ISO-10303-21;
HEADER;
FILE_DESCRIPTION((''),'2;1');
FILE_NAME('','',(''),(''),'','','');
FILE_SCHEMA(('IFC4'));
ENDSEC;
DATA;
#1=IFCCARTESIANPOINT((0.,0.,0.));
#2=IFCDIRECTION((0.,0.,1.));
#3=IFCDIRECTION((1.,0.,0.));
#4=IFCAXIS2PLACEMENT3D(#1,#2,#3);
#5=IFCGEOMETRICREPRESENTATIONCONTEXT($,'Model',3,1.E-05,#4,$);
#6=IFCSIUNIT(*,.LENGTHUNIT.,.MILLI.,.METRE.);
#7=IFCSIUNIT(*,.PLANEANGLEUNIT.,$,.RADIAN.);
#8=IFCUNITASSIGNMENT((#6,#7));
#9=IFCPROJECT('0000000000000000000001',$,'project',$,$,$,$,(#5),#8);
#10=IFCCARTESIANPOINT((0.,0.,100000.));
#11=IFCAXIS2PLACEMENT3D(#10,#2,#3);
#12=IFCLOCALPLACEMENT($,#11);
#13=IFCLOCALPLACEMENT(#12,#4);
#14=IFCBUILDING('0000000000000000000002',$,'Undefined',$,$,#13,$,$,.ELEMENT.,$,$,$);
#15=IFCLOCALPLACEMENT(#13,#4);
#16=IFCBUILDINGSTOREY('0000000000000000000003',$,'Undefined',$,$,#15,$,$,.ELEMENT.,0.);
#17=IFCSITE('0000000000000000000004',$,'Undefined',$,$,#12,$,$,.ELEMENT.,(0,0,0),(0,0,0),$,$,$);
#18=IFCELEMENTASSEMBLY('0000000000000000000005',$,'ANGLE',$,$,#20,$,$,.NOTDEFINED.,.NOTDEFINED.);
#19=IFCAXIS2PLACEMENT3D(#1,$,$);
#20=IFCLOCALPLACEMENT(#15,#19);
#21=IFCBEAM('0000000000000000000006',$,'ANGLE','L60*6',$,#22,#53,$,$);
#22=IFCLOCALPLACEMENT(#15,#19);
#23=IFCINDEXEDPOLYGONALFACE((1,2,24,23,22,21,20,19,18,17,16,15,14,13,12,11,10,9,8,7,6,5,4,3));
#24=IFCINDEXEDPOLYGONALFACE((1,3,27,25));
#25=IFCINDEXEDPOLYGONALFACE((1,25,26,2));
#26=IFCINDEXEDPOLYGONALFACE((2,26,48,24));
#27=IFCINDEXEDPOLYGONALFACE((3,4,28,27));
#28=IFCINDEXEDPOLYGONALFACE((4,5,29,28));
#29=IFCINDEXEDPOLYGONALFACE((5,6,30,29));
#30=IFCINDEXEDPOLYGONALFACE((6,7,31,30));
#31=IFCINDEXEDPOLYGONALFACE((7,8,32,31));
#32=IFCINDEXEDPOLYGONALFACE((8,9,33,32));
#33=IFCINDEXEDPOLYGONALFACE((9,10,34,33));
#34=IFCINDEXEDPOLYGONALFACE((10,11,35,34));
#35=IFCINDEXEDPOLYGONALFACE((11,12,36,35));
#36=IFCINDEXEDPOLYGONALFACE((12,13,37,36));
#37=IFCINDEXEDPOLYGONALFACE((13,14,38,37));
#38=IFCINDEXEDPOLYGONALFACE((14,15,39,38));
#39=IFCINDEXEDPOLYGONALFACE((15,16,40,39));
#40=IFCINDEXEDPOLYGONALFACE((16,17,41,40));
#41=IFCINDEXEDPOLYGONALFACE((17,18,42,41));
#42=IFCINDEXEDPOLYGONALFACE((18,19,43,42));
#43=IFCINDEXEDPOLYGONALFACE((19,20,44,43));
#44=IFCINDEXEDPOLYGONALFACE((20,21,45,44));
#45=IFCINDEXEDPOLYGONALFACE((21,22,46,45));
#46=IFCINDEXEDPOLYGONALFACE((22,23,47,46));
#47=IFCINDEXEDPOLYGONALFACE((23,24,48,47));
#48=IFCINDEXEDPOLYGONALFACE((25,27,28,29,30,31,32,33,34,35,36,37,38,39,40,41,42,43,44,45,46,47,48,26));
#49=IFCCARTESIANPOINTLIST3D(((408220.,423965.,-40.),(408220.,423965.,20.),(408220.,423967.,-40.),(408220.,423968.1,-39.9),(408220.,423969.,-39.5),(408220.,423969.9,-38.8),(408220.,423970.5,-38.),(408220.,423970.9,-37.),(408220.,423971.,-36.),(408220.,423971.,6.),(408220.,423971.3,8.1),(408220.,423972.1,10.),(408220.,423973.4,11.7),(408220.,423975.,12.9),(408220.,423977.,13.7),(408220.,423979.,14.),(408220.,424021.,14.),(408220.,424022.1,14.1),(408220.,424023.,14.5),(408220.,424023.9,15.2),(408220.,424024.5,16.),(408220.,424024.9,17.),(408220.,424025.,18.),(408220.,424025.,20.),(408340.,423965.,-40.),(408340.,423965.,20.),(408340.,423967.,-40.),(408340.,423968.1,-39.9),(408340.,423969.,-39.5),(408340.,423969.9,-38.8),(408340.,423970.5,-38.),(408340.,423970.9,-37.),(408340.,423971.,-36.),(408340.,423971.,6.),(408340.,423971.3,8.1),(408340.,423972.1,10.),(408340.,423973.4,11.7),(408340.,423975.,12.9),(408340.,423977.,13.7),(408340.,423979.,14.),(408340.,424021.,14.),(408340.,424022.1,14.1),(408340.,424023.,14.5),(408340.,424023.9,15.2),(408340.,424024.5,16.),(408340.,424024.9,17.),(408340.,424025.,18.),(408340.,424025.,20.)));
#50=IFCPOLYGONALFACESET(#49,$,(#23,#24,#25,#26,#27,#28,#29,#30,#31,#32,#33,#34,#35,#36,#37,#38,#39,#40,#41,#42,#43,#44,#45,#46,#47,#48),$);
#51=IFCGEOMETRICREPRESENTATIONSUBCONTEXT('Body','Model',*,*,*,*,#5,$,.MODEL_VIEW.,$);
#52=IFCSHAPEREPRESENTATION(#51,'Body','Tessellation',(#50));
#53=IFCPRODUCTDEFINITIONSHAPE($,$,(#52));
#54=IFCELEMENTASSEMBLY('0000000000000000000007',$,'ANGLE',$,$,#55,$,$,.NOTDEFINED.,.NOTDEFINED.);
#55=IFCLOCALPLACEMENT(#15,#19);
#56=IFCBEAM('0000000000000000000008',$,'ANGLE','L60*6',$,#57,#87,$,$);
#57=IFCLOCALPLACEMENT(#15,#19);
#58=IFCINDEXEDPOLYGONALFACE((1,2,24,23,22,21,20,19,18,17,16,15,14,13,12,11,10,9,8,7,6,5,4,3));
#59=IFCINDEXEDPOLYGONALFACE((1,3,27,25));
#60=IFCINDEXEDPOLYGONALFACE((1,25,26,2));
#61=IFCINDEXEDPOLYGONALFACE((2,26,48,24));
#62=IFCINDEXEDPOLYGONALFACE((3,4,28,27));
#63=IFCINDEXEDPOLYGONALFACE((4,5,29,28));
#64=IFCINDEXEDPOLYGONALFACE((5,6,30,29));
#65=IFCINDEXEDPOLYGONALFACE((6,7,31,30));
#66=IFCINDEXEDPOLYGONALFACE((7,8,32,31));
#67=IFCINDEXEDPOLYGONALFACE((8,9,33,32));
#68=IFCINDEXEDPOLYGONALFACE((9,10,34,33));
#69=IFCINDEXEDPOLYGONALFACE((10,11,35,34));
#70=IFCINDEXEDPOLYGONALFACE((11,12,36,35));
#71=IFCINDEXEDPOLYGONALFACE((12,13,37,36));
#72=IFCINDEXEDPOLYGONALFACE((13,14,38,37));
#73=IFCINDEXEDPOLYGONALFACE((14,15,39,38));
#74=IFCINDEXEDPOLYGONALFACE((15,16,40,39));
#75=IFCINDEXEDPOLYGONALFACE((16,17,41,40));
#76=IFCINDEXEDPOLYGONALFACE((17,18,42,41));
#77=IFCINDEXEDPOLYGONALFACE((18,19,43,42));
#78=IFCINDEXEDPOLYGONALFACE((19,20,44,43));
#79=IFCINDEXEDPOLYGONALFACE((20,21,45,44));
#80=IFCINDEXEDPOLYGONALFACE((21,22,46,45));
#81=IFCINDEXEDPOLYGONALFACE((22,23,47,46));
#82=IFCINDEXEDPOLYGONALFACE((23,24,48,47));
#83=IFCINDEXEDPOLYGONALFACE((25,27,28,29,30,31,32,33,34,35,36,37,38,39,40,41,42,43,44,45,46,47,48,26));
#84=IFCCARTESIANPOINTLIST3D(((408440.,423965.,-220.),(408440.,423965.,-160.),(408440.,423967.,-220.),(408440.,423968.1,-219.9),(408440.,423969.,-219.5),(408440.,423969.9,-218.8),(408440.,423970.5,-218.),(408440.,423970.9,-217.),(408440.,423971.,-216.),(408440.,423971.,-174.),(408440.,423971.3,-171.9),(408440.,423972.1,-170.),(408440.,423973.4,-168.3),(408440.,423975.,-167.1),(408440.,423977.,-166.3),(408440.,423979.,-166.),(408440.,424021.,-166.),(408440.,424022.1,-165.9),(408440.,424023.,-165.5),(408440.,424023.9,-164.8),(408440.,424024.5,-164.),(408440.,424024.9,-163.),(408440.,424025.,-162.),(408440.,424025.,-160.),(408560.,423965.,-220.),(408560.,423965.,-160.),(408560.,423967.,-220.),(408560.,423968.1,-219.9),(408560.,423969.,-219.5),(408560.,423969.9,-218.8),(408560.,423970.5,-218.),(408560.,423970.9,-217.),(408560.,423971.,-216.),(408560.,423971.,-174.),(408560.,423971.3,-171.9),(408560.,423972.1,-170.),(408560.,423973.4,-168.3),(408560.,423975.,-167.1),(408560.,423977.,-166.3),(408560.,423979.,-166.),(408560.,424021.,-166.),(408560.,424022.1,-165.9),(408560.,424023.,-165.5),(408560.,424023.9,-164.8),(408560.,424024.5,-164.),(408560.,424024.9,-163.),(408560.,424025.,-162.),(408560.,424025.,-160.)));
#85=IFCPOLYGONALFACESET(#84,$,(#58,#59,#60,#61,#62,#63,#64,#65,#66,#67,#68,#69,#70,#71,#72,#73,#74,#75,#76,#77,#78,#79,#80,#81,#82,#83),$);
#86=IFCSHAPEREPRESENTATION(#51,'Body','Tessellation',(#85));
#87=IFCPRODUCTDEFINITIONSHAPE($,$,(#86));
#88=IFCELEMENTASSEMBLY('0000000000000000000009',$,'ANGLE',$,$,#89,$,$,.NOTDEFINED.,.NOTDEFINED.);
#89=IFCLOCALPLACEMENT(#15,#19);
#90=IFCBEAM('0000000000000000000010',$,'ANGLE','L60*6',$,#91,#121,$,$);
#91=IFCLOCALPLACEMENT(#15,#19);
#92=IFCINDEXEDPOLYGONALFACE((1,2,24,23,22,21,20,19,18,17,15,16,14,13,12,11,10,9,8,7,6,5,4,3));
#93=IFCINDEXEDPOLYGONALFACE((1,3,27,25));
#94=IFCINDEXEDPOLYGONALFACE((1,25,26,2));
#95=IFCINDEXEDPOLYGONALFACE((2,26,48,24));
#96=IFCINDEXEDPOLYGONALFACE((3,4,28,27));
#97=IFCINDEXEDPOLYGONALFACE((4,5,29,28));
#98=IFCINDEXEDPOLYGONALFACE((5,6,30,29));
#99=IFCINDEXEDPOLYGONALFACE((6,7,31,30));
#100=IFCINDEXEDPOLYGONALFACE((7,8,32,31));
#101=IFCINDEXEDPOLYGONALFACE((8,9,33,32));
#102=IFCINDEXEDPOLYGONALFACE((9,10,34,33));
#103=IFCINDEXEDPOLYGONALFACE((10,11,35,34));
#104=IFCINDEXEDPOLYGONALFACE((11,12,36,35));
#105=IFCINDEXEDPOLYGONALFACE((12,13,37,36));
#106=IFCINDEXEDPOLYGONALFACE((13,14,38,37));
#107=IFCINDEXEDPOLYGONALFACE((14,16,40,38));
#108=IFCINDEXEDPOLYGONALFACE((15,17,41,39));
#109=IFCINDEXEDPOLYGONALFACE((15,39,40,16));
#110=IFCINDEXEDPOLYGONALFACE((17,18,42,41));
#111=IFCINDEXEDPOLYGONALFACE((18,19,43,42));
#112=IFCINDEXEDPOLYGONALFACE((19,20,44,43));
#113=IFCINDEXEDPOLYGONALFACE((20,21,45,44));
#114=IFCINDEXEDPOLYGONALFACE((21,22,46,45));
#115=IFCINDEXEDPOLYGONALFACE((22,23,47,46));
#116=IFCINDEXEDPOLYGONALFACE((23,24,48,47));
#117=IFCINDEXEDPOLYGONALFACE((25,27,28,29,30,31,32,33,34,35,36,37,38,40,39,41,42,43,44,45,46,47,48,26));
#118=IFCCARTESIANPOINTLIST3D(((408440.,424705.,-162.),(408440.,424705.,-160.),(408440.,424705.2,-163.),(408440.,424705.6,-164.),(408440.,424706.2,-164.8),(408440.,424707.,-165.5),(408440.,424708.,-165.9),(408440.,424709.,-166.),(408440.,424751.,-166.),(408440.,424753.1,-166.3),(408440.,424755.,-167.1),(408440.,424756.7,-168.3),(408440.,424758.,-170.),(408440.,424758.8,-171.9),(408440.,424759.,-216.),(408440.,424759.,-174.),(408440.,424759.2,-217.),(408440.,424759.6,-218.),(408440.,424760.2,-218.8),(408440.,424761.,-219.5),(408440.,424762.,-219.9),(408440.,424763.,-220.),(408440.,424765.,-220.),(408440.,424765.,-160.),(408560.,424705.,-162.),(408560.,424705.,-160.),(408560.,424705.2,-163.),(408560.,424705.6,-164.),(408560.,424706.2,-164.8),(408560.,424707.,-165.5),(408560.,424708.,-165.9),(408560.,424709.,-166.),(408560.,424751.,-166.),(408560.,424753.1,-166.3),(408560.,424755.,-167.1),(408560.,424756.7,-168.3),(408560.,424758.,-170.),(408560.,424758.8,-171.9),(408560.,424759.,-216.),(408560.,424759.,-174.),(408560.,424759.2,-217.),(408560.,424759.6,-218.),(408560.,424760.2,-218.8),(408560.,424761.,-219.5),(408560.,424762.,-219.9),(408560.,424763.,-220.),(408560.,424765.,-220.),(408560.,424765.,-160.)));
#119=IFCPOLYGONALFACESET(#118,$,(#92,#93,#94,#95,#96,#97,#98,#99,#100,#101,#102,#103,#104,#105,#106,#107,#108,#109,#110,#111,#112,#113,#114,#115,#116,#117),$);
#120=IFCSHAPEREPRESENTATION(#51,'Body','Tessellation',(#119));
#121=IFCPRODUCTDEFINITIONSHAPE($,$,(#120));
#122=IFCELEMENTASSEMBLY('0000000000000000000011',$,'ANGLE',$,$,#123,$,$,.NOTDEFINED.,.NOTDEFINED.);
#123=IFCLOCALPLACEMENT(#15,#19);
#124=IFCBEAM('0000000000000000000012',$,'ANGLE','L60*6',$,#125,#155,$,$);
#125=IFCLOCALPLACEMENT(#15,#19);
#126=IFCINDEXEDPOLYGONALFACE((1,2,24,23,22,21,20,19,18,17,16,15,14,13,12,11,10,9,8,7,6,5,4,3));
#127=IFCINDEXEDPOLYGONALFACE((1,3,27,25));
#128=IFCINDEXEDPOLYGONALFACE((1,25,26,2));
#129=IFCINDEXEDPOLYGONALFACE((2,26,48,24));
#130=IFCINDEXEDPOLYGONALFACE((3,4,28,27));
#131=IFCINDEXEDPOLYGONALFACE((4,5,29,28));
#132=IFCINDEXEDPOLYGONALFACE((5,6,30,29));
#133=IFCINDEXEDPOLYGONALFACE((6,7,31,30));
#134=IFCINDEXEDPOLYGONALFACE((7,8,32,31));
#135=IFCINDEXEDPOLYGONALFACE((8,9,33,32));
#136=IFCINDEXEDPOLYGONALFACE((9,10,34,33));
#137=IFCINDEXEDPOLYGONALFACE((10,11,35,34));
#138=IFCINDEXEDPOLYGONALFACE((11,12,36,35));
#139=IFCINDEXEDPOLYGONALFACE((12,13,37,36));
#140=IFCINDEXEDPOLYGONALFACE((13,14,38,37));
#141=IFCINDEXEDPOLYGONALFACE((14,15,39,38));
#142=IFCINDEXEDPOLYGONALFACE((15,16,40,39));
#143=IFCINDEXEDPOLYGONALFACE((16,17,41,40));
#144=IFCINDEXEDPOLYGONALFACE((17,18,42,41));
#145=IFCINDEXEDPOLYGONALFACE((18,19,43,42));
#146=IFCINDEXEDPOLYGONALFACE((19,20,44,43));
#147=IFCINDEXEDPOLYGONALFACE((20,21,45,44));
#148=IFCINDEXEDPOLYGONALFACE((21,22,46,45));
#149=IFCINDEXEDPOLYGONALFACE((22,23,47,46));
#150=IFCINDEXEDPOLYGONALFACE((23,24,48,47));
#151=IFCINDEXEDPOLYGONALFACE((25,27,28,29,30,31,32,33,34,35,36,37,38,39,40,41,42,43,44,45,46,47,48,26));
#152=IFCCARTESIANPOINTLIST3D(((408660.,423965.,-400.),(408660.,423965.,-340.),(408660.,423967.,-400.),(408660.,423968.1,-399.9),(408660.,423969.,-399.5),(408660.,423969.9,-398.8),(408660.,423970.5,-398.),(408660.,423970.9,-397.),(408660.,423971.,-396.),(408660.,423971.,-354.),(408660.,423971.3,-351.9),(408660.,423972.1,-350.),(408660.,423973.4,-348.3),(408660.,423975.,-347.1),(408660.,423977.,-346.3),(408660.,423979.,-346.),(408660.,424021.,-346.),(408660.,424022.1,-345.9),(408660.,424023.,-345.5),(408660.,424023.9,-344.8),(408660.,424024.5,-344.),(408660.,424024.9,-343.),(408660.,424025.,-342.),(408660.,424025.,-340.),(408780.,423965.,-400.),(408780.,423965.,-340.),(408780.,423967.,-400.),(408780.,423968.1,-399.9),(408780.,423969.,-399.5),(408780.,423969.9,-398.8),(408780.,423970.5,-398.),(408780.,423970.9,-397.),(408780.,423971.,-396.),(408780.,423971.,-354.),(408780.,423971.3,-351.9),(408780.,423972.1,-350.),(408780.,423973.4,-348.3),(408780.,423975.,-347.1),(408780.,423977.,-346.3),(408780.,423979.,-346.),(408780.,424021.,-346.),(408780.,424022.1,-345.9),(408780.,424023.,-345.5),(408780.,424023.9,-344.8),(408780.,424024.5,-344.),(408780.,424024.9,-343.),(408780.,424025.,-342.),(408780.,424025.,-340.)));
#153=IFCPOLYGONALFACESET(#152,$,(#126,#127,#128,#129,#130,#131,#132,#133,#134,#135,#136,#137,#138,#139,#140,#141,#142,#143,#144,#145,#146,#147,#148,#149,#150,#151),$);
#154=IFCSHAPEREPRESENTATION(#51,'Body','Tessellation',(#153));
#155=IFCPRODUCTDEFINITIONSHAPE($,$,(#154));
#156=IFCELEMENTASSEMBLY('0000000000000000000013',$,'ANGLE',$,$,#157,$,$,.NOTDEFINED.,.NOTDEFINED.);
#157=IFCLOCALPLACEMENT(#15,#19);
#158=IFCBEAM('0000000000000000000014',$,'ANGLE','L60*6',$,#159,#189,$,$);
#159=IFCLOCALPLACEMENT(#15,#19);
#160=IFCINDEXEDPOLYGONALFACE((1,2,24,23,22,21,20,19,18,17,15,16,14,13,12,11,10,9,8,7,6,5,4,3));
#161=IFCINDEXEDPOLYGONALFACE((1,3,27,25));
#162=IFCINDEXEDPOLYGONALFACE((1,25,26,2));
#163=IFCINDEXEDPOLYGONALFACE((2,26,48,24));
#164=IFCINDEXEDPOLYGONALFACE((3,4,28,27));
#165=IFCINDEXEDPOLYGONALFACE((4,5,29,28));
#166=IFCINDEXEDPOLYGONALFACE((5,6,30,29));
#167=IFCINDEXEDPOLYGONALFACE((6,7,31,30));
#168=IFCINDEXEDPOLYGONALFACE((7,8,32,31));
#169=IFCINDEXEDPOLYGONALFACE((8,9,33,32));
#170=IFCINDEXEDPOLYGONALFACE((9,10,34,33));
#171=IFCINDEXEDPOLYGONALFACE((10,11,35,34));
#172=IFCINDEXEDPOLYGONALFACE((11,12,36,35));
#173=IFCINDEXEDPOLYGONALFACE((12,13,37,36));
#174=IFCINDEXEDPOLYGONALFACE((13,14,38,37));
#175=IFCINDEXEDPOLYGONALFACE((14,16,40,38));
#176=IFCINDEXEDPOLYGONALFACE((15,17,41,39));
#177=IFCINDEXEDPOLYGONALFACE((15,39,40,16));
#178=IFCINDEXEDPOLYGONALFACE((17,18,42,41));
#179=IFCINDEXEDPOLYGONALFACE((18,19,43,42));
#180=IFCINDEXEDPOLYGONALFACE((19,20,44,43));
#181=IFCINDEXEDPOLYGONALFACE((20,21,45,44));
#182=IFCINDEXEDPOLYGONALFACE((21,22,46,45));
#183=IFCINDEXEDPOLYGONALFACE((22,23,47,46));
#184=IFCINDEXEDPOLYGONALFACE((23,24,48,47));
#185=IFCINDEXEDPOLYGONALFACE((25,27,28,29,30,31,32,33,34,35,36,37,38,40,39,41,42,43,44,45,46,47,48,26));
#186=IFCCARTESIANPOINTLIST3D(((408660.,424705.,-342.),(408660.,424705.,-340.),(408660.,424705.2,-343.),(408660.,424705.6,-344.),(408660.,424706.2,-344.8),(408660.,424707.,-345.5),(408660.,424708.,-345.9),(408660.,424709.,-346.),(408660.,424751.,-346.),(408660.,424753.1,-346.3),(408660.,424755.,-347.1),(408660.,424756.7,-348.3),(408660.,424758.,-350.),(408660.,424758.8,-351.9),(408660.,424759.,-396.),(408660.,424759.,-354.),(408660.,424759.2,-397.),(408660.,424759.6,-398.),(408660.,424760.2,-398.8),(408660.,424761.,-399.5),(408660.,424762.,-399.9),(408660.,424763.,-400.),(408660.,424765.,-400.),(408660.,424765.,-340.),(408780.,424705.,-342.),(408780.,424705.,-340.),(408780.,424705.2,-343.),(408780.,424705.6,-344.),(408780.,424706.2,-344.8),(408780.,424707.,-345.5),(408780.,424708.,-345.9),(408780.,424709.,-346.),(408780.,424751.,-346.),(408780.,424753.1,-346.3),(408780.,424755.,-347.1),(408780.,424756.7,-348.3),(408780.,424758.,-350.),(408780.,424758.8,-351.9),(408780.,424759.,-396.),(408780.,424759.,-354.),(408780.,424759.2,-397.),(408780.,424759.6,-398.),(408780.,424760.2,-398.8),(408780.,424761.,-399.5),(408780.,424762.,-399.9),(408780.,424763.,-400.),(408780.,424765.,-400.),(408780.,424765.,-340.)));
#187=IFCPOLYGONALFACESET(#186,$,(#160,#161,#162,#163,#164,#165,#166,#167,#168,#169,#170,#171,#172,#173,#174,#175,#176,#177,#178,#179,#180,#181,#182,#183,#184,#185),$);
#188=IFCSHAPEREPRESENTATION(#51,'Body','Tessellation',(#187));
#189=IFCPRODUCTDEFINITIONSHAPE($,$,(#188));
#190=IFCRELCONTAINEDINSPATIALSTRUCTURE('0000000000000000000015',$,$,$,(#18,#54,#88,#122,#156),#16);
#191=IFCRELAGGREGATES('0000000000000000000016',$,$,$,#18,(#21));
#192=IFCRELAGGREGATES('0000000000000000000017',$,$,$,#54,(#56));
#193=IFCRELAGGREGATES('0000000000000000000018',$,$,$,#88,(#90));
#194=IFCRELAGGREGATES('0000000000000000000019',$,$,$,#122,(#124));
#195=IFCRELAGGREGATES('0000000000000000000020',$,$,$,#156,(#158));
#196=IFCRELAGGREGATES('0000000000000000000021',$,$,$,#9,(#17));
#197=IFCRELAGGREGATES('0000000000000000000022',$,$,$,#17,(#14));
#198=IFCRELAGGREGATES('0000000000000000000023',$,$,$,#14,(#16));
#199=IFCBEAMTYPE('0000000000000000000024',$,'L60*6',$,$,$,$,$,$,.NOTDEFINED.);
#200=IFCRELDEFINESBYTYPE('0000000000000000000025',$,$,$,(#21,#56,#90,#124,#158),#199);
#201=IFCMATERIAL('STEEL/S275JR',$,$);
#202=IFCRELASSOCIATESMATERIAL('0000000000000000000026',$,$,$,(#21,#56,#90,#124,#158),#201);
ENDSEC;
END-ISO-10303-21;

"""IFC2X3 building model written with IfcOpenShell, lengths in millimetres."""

from ifc_helpers import new_model, si_unit, frame, origin_with_axes, origin_2d_with_axis, place, context, subcontext, project, spatial, l_section, extrude, material, type_object, element, aggregate, save


model = new_model("IFC2X3")

# Units and contexts
model_context = context("Model", 3, precision=1e-05, world=origin_with_axes())
body_context = subcontext(model_context, "Body", "Model", "MODEL_VIEW")
ifc_project = project(units=[si_unit("LENGTHUNIT", "METRE", prefix="MILLI"), si_unit("PLANEANGLEUNIT", "RADIAN")], contexts=[model_context])

# Site, building, storey
site_placement = place(None, frame((0.0, 0.0, 100000.0), z_axis=(0.0, 0.0, 1.0), x_axis=(1.0, 0.0, 0.0)))
site = spatial("IfcSite", under=ifc_project, at=site_placement, Name="Undefined", CompositionType="ELEMENT", RefLatitude=(0, 0, 0), RefLongitude=(0, 0, 0))
building_placement = place(site_placement, origin_with_axes())
building = spatial("IfcBuilding", under=site, at=building_placement, Name="Undefined", CompositionType="ELEMENT")
storey_placement = place(building_placement, origin_with_axes())
storey = spatial("IfcBuildingStorey", under=building, at=storey_placement, Name="Undefined", CompositionType="ELEMENT", Elevation=0.0)

# Shared definitions
ifc_material_1 = material(Name="STEEL/S275JR")

# Element assemblies, beams
assembly_1_placement = place(storey_placement, origin_with_axes())
assembly_1 = element("IfcElementAssembly", 1, at=assembly_1_placement, inside=storey, Name="ANGLE", AssemblyPlace="NOTDEFINED", PredefinedType="NOTDEFINED")
beam_type_1 = type_object("IfcBeamType", Name="L60*6", PredefinedType="NOTDEFINED")
beam_1_placement = place(assembly_1_placement, frame((408340.0, 423995.0, -10.0), z_axis=(0.0, 1.0, 0.0), x_axis=(-1.0, 0.0, 0.0)))
beam_1 = element("IfcBeam", 2, at=beam_1_placement, type_object=beam_type_1, material=ifc_material_1, Name="ANGLE", Description="L60*6", context=body_context, shape_type="SweptSolid", body=[
    extrude(l_section(Depth=60.0, Width=60.0, Thickness=6.0, FilletRadius=8.0, EdgeRadius=4.0, at=origin_2d_with_axis()), frame((120.0, 0.0, 0.0), z_axis=(-1.0, 0.0, 0.0), x_axis=(0.0, -1.0, 0.0)), (0.0, 0.0, 1.0), 120.0),
])
aggregate(assembly_1, [beam_1])
assembly_2_placement = place(storey_placement, origin_with_axes())
assembly_2 = element("IfcElementAssembly", 3, at=assembly_2_placement, inside=storey, Name="ANGLE", AssemblyPlace="NOTDEFINED", PredefinedType="NOTDEFINED")
beam_2_placement = place(assembly_2_placement, frame((408560.0, 423995.0, -190.0), z_axis=(0.0, 1.0, 0.0), x_axis=(-1.0, 0.0, 0.0)))
beam_2 = element("IfcBeam", 4, at=beam_2_placement, type_object=beam_type_1, material=ifc_material_1, Name="ANGLE", Description="L60*6", context=body_context, shape_type="SweptSolid", body=[
    extrude(l_section(Depth=60.0, Width=60.0, Thickness=6.0, FilletRadius=8.0, EdgeRadius=4.0, at=origin_2d_with_axis()), frame((120.0, 0.0, 0.0), z_axis=(-1.0, 0.0, 0.0), x_axis=(0.0, -1.0, 0.0)), (0.0, 0.0, 1.0), 120.0),
])
assembly_3_placement = place(storey_placement, origin_with_axes())
assembly_3 = element("IfcElementAssembly", 5, at=assembly_3_placement, inside=storey, Name="ANGLE", AssemblyPlace="NOTDEFINED", PredefinedType="NOTDEFINED")
beam_3_placement = place(assembly_3_placement, frame((408440.0, 424735.0, -190.0), z_axis=(0.0, -1.0, 0.0), x_axis=(1.0, 0.0, 0.0)))
beam_3 = element("IfcBeam", 6, at=beam_3_placement, type_object=beam_type_1, material=ifc_material_1, Name="ANGLE", Description="L60*6", context=body_context, shape_type="SweptSolid", body=[
    extrude(l_section(Depth=60.0, Width=60.0, Thickness=6.0, FilletRadius=8.0, EdgeRadius=4.0, at=origin_2d_with_axis()), frame((120.0, 0.0, 0.0), z_axis=(-1.0, 0.0, 0.0), x_axis=(0.0, -1.0, 0.0)), (0.0, 0.0, 1.0), 120.0),
])
assembly_4_placement = place(storey_placement, origin_with_axes())
assembly_4 = element("IfcElementAssembly", 7, at=assembly_4_placement, inside=storey, Name="ANGLE", AssemblyPlace="NOTDEFINED", PredefinedType="NOTDEFINED")
beam_4_placement = place(assembly_4_placement, frame((408780.0, 423995.0, -370.0), z_axis=(0.0, 1.0, 0.0), x_axis=(-1.0, 0.0, 0.0)))
beam_4 = element("IfcBeam", 8, at=beam_4_placement, type_object=beam_type_1, material=ifc_material_1, Name="ANGLE", Description="L60*6", context=body_context, shape_type="SweptSolid", body=[
    extrude(l_section(Depth=60.0, Width=60.0, Thickness=6.0, FilletRadius=8.0, EdgeRadius=4.0, at=origin_2d_with_axis()), frame((120.0, 0.0, 0.0), z_axis=(-1.0, 0.0, 0.0), x_axis=(0.0, -1.0, 0.0)), (0.0, 0.0, 1.0), 120.0),
])
assembly_5_placement = place(storey_placement, origin_with_axes())
assembly_5 = element("IfcElementAssembly", 9, at=assembly_5_placement, inside=storey, Name="ANGLE", AssemblyPlace="NOTDEFINED", PredefinedType="NOTDEFINED")
beam_5_placement = place(assembly_5_placement, frame((408660.0, 424735.0, -370.0), z_axis=(0.0, -1.0, 0.0), x_axis=(1.0, 0.0, 0.0)))
beam_5 = element("IfcBeam", 10, at=beam_5_placement, type_object=beam_type_1, material=ifc_material_1, Name="ANGLE", Description="L60*6", context=body_context, shape_type="SweptSolid", body=[
    extrude(l_section(Depth=60.0, Width=60.0, Thickness=6.0, FilletRadius=8.0, EdgeRadius=4.0, at=origin_2d_with_axis()), frame((120.0, 0.0, 0.0), z_axis=(-1.0, 0.0, 0.0), x_axis=(0.0, -1.0, 0.0)), (0.0, 0.0, 1.0), 120.0),
])

aggregate(assembly_2, [beam_2])
aggregate(assembly_3, [beam_3])
aggregate(assembly_4, [beam_4])
aggregate(assembly_5, [beam_5])

save(model, "model.ifc")
